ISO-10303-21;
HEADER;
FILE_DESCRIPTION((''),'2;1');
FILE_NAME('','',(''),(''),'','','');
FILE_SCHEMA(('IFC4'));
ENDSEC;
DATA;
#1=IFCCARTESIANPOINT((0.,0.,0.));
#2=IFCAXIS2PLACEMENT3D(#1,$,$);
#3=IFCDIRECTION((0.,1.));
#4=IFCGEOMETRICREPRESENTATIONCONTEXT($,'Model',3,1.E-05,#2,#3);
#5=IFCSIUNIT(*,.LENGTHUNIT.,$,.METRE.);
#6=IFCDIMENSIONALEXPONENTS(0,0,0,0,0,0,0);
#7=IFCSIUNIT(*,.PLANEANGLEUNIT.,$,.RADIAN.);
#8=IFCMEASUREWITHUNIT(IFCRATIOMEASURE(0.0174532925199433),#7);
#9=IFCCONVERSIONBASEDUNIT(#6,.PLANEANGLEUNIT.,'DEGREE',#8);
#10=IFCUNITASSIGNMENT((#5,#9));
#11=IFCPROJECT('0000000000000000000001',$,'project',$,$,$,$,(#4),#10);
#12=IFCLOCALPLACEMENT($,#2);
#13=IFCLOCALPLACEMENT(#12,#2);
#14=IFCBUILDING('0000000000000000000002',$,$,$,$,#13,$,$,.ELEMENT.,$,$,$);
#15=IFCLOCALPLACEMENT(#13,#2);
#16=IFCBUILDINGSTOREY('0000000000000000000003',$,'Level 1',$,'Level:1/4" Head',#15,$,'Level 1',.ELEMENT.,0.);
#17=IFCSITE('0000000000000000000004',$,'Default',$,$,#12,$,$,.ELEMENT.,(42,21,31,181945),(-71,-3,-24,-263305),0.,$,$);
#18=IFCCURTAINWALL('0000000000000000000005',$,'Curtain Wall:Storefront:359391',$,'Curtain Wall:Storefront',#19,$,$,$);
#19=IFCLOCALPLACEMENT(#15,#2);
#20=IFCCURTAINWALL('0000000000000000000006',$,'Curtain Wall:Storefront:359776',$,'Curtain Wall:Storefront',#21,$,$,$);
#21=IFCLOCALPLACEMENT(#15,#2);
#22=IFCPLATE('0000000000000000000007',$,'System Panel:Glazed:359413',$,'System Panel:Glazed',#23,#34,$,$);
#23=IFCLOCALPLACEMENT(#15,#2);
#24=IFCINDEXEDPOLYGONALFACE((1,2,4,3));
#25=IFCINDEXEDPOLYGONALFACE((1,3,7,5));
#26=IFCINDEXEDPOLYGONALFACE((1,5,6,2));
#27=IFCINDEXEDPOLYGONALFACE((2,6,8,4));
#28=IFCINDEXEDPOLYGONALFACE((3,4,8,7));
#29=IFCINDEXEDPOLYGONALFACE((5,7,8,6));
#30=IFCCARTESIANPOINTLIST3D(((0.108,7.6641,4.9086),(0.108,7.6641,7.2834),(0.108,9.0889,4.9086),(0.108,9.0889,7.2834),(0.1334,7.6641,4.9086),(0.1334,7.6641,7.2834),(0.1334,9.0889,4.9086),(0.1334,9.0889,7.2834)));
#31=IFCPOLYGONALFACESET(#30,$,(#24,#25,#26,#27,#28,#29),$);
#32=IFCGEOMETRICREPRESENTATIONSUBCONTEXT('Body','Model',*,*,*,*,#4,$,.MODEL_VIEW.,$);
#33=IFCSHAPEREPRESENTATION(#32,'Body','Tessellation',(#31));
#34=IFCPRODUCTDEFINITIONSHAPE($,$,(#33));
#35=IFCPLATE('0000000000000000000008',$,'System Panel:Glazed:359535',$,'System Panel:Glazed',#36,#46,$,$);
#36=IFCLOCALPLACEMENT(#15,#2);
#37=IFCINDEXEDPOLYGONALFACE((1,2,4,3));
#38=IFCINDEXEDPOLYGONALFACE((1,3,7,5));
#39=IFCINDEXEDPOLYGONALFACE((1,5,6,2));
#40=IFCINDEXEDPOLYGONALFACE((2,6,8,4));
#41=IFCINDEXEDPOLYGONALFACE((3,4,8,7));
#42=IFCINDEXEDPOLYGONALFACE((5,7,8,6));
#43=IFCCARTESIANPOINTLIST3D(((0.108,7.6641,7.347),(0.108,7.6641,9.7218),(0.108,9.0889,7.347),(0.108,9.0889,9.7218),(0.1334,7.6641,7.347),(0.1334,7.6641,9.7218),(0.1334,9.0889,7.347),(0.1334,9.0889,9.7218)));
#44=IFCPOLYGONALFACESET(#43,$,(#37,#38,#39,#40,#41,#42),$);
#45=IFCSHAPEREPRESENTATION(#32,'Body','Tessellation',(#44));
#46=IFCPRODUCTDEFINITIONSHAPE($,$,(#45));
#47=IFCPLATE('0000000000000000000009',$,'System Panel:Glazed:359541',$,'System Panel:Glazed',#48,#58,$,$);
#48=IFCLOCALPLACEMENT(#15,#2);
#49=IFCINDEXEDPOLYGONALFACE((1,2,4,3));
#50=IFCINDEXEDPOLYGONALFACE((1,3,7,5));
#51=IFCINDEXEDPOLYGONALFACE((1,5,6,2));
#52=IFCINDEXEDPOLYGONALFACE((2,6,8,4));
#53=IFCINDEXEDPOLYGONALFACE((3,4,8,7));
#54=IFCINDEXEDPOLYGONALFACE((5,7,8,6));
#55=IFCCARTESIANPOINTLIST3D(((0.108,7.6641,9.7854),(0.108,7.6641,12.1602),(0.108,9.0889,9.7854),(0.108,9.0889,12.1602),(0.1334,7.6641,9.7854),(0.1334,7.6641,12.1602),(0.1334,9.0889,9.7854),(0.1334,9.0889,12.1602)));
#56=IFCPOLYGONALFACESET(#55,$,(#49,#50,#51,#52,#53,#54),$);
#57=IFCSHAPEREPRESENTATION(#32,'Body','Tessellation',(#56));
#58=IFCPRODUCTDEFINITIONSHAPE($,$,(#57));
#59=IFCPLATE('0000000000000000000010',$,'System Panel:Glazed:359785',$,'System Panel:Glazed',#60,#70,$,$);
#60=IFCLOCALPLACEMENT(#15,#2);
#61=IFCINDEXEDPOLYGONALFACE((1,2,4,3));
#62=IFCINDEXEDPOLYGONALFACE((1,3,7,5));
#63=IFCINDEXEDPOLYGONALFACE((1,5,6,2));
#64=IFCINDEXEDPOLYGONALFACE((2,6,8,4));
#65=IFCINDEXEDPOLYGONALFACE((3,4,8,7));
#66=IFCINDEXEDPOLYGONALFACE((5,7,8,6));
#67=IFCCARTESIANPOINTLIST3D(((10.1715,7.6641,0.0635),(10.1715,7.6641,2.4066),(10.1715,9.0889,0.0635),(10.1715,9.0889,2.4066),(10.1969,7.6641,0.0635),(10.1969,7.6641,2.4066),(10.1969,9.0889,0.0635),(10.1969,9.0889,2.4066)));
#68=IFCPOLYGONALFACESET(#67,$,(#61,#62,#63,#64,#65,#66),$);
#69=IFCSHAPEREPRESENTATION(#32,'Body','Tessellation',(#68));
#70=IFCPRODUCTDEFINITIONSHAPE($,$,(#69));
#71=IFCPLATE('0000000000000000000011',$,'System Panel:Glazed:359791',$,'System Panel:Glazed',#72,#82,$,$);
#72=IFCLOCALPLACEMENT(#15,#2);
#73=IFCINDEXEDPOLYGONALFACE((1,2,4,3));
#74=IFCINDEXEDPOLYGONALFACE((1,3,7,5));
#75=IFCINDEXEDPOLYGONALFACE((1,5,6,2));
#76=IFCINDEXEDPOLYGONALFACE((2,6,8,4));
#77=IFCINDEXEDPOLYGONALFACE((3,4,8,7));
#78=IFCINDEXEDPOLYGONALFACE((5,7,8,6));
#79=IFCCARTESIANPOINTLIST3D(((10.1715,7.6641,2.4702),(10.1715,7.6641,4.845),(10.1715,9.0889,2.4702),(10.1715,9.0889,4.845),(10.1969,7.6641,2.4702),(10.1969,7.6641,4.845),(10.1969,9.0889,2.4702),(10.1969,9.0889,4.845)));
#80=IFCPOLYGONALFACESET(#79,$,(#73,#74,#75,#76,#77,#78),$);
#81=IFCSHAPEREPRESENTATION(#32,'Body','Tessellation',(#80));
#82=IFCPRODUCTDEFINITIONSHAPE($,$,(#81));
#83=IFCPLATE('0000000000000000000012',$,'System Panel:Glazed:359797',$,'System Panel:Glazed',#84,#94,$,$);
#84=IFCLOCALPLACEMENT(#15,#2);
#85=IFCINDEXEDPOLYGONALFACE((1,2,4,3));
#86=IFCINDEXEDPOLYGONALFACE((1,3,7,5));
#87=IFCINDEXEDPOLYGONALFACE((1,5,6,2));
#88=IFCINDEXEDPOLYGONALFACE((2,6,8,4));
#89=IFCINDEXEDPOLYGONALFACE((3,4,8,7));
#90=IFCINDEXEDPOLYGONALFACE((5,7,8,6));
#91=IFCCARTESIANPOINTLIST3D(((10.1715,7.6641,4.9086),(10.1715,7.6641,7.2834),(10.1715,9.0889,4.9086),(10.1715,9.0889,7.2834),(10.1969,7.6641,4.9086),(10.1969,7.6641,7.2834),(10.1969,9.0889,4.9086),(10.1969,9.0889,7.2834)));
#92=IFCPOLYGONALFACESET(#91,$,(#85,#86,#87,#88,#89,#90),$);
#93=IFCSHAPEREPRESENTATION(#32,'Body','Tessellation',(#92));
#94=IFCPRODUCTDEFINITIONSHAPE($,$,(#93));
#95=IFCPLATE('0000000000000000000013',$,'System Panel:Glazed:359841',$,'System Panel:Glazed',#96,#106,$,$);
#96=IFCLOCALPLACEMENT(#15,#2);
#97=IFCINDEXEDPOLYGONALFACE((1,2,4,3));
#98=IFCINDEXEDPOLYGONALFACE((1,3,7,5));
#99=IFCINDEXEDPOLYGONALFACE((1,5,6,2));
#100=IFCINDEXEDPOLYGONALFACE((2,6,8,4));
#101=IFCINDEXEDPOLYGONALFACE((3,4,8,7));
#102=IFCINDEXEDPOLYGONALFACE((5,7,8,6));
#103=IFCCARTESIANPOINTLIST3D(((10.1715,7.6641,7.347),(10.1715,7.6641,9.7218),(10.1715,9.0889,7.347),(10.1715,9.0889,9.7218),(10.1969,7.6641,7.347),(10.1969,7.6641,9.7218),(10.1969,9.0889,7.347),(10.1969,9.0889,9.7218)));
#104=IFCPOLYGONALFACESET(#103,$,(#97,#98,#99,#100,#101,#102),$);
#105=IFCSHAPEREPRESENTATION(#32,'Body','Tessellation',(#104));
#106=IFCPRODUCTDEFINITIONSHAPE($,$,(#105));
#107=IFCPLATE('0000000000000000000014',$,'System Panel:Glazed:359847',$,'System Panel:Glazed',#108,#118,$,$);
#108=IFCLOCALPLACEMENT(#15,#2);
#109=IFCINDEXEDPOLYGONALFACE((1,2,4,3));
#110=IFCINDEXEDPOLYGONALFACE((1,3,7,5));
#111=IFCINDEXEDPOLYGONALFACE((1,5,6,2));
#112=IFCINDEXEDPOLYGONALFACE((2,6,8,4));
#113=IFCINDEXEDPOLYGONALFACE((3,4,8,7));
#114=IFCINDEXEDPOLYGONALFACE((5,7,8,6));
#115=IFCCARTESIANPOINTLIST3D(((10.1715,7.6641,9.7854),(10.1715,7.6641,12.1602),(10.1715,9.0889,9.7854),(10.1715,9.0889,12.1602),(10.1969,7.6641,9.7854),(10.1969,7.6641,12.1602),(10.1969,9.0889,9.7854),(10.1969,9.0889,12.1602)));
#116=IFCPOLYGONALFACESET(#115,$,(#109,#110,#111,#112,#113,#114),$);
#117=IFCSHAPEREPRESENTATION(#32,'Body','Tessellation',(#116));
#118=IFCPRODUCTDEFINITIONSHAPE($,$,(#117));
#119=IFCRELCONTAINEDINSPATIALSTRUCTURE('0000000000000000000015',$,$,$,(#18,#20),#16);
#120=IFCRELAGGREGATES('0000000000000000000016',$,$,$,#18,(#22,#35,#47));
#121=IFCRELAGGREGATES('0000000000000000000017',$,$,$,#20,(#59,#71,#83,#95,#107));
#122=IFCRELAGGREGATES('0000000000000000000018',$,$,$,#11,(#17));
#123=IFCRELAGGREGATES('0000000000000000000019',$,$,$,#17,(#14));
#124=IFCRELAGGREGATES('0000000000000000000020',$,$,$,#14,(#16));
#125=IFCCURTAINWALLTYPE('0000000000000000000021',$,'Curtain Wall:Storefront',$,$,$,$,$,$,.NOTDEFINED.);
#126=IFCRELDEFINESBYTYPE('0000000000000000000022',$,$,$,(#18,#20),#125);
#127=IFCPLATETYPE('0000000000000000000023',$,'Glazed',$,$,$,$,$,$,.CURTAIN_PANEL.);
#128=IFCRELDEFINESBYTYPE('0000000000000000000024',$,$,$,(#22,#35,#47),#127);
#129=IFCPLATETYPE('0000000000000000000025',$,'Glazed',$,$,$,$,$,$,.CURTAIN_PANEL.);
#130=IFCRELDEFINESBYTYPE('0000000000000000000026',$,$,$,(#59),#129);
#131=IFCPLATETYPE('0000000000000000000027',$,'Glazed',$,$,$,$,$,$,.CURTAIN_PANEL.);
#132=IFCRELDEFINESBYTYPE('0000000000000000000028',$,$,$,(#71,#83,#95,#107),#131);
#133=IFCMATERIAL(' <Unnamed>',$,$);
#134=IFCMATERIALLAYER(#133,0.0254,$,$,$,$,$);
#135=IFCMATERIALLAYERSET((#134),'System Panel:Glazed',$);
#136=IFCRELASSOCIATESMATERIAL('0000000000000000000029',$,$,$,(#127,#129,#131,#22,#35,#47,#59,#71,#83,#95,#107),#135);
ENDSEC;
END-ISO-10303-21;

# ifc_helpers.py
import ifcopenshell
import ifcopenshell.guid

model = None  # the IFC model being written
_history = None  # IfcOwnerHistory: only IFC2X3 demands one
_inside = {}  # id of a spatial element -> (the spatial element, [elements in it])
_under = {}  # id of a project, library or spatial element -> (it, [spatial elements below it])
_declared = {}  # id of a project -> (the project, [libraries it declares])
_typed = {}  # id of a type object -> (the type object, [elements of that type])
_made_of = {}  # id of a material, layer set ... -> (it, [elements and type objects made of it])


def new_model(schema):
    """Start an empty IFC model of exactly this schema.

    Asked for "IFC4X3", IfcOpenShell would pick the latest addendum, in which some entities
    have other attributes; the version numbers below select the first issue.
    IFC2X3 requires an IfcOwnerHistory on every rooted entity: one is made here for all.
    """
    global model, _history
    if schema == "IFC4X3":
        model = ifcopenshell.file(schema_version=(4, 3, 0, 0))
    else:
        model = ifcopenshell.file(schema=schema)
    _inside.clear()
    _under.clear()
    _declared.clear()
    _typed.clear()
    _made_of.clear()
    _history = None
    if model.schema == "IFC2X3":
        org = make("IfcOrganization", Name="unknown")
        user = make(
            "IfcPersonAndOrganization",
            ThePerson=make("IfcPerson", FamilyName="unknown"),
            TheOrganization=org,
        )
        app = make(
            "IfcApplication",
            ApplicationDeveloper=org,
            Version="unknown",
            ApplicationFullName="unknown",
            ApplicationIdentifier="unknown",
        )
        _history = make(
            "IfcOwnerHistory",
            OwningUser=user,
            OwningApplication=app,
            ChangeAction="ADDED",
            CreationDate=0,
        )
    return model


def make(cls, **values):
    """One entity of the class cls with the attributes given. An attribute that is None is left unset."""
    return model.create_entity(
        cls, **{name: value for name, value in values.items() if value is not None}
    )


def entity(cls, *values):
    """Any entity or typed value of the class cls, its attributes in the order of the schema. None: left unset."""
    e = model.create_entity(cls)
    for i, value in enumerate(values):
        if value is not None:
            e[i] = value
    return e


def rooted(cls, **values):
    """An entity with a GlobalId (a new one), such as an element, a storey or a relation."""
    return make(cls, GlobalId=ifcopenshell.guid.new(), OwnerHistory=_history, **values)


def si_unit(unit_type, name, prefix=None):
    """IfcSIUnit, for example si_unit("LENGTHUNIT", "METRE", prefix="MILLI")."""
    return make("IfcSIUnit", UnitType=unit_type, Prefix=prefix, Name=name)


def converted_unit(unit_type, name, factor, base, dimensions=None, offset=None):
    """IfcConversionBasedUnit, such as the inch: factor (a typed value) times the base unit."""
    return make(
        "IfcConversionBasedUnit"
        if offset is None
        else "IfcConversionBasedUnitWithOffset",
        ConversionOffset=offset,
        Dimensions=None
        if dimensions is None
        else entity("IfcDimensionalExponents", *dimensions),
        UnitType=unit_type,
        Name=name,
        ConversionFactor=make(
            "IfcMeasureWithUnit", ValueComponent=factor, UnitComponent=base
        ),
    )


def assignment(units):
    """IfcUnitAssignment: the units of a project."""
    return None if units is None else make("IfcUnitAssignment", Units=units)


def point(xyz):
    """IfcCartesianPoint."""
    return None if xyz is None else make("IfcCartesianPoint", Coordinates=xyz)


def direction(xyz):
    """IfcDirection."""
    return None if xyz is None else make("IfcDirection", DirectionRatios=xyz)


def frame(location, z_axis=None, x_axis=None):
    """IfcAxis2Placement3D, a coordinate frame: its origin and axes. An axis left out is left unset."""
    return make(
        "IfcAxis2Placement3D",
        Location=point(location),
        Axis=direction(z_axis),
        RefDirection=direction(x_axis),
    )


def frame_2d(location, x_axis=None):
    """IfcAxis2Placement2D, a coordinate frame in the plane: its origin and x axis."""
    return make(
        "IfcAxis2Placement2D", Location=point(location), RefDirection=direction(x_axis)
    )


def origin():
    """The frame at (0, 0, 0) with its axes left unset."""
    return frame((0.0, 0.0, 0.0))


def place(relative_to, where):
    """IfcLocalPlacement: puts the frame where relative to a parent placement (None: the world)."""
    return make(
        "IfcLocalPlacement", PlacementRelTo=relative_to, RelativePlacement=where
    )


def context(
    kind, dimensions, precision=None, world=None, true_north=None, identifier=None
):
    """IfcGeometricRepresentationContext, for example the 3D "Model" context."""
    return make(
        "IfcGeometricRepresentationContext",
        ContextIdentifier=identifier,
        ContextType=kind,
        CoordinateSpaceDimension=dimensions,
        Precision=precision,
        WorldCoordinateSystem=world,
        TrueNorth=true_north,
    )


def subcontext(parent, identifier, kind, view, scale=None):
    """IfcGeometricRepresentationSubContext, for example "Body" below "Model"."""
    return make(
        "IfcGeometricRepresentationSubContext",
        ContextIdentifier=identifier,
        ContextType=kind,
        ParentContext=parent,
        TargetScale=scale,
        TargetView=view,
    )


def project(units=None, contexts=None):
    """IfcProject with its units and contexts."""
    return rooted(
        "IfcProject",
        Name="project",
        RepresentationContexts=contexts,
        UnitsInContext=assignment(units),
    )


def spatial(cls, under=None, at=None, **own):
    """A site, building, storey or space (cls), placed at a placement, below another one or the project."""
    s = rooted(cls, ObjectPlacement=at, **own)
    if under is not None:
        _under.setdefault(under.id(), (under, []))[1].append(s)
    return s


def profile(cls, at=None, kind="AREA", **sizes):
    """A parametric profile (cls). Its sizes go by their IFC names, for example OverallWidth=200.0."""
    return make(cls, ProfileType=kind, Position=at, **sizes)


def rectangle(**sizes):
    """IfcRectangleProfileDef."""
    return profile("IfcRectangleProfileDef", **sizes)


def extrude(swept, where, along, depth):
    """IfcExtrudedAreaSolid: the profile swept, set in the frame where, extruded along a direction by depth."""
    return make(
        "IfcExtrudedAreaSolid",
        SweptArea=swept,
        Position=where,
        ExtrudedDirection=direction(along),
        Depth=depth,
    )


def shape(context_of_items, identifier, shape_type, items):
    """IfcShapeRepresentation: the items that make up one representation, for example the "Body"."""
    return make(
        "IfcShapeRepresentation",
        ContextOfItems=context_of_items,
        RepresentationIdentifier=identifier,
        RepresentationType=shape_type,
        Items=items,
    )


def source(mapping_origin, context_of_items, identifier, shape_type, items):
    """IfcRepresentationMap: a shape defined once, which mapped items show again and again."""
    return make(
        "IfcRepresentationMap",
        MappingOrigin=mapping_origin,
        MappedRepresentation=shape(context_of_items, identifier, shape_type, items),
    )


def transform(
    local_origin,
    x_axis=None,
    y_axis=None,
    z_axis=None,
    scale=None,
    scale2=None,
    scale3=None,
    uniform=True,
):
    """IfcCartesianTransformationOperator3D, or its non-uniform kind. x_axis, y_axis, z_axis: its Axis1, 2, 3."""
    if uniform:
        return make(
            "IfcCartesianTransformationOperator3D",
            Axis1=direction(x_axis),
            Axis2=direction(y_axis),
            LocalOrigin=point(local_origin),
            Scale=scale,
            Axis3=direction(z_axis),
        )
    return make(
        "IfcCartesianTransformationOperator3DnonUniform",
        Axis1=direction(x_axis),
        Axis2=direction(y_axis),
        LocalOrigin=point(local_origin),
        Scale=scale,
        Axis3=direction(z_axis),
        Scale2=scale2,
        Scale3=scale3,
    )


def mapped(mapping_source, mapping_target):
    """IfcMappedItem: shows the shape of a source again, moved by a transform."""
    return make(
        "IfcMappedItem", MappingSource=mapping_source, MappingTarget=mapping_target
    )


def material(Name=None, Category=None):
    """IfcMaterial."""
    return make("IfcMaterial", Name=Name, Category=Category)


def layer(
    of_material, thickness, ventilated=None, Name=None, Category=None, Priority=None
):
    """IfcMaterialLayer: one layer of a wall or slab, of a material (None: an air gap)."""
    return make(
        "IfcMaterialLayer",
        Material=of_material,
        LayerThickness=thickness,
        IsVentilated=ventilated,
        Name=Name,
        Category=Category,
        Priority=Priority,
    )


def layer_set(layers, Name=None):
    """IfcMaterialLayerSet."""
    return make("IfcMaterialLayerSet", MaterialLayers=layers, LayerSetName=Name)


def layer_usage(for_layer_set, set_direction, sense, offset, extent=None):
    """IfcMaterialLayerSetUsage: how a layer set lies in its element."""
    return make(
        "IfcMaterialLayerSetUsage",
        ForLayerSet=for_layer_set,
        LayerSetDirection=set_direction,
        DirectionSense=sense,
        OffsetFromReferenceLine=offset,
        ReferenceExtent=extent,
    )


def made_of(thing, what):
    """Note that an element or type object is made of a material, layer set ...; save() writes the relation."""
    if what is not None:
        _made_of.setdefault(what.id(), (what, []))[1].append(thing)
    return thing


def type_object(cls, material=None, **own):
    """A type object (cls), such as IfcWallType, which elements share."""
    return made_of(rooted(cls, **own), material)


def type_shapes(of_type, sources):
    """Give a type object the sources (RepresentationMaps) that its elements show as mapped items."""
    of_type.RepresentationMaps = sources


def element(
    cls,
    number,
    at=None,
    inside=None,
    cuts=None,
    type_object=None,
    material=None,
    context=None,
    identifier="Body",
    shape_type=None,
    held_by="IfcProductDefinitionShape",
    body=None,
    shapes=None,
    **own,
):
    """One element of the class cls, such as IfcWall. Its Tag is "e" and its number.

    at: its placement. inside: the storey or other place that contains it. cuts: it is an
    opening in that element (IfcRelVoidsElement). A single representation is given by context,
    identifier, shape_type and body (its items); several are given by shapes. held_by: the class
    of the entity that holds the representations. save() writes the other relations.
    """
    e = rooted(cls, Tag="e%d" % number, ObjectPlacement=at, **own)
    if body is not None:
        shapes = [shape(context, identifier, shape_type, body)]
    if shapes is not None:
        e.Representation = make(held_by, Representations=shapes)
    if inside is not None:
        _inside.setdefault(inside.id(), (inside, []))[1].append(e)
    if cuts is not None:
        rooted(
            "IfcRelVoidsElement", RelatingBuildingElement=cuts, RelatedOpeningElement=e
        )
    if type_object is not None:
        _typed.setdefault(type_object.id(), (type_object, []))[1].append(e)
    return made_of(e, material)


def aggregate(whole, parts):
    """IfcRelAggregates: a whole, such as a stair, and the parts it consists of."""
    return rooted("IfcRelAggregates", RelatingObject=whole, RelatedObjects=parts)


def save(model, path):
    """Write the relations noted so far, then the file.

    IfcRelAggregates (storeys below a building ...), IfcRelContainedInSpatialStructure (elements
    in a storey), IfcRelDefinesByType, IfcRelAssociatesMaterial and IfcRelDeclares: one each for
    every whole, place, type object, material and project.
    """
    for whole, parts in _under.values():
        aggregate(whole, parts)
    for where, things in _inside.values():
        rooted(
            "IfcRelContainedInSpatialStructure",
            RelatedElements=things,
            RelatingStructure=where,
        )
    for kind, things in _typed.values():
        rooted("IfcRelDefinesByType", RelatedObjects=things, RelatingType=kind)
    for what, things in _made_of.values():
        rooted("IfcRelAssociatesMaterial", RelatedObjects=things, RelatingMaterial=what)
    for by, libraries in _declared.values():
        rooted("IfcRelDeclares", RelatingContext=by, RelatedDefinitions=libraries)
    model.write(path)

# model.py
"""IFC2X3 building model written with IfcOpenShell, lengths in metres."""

from ifc_helpers import new_model, entity, si_unit, converted_unit, direction, frame, frame_2d, origin, place, context, subcontext, project, spatial, rectangle, extrude, source, transform, mapped, material, layer, layer_set, layer_usage, type_object, type_shapes, element, aggregate, save


model = new_model("IFC2X3")

# Units and contexts
model_context = context("Model", 3, precision=1e-05, world=origin(), true_north=direction((0.0, 1.0)))
body_context = subcontext(model_context, "Body", "Model", "MODEL_VIEW")
ifc_project = project(units=[si_unit("LENGTHUNIT", "METRE"), converted_unit("PLANEANGLEUNIT", "DEGREE", entity("IfcRatioMeasure", 0.0174532925199433), si_unit("PLANEANGLEUNIT", "RADIAN"), dimensions=[0, 0, 0, 0, 0, 0, 0])], contexts=[model_context])

# Site, building, storey
site_placement = place(None, origin())
site = spatial("IfcSite", under=ifc_project, at=site_placement, Name="Default", CompositionType="ELEMENT", RefLatitude=(42, 21, 31, 181945), RefLongitude=(-71, -3, -24, -263305), RefElevation=0.0)
building_placement = place(site_placement, origin())
building = spatial("IfcBuilding", under=site, at=building_placement, CompositionType="ELEMENT")
storey_placement = place(building_placement, origin())
storey = spatial("IfcBuildingStorey", under=building, at=storey_placement, Name="Level 1", ObjectType="Level:1/4\" Head", LongName="Level 1", CompositionType="ELEMENT", Elevation=0.0)

# Curtain walls
curtain_wall_type = type_object("IfcCurtainWallType", Name="Curtain Wall:Storefront", PredefinedType="NOTDEFINED")
curtain_wall_1_placement = place(storey_placement, origin())
curtain_wall_1 = element("IfcCurtainWall", 1, at=curtain_wall_1_placement, inside=storey, type_object=curtain_wall_type, Name="Curtain Wall:Storefront:359391", ObjectType="Curtain Wall:Storefront")
curtain_wall_2_placement = place(storey_placement, origin())
curtain_wall_2 = element("IfcCurtainWall", 2, at=curtain_wall_2_placement, inside=storey, type_object=curtain_wall_type, Name="Curtain Wall:Storefront:359776", ObjectType="Curtain Wall:Storefront")

# Plates
ifc_material_1 = material(Name=" <Unnamed>")
ifc_layer = layer(ifc_material_1, 0.0254)
ifc_layer_set = layer_set([ifc_layer], Name="System Panel:Glazed")
plate_type_1 = type_object("IfcPlateType", Name="Glazed", PredefinedType="CURTAIN_PANEL", material=ifc_layer_set)
shared_shape_1 = source(origin(), body_context, "Body", "SweptSolid", [
    extrude(rectangle(XDim=0.0254, YDim=1.4248, at=frame_2d((0.0, 0.0), x_axis=(1.0, 0.0))), frame((0.7124, 0.0127, 0.0), z_axis=(0.0, 0.0, 1.0), x_axis=(0.0, 1.0, 0.0)), (0.0, 0.0, 1.0), 2.3749),
])
type_shapes(plate_type_1, [shared_shape_1])
ifc_layer_usage_1 = layer_usage(ifc_layer_set, "AXIS3", "POSITIVE", 0.1042)
plate_1_placement = place(curtain_wall_1_placement, frame((0.1334, 7.6641, 4.9085), z_axis=(0.0, 0.0, 1.0), x_axis=(0.0, 1.0, 0.0)))
plate_1 = element("IfcPlate", 3, at=plate_1_placement, type_object=plate_type_1, material=ifc_layer_usage_1, Name="System Panel:Glazed:359413", ObjectType="System Panel:Glazed", context=body_context, shape_type="MappedRepresentation", body=[
    mapped(shared_shape_1, transform((0.0, 0.0, 0.0), scale=1.0)),
])
ifc_layer_usage_2 = layer_usage(ifc_layer_set, "AXIS3", "POSITIVE", 0.1042)
plate_2_placement = place(curtain_wall_1_placement, frame((0.1334, 7.6641, 7.3469), z_axis=(0.0, 0.0, 1.0), x_axis=(0.0, 1.0, 0.0)))
plate_2 = element("IfcPlate", 4, at=plate_2_placement, type_object=plate_type_1, material=ifc_layer_usage_2, Name="System Panel:Glazed:359535", ObjectType="System Panel:Glazed", context=body_context, shape_type="MappedRepresentation", body=[
    mapped(shared_shape_1, transform((0.0, 0.0, 0.0), scale=1.0)),
])
ifc_layer_usage_3 = layer_usage(ifc_layer_set, "AXIS3", "POSITIVE", 0.1042)
plate_3_placement = place(curtain_wall_1_placement, frame((0.1334, 7.6641, 9.7853), z_axis=(0.0, 0.0, 1.0), x_axis=(0.0, 1.0, 0.0)))
plate_3 = element("IfcPlate", 5, at=plate_3_placement, type_object=plate_type_1, material=ifc_layer_usage_3, Name="System Panel:Glazed:359541", ObjectType="System Panel:Glazed", context=body_context, shape_type="MappedRepresentation", body=[
    mapped(shared_shape_1, transform((0.0, 0.0, 0.0), scale=1.0)),
])
aggregate(curtain_wall_1, [plate_1, plate_2, plate_3])
ifc_layer_usage_4 = layer_usage(ifc_layer_set, "AXIS3", "POSITIVE", 0.1042)
plate_type_2 = type_object("IfcPlateType", Name="Glazed", PredefinedType="CURTAIN_PANEL", material=ifc_layer_set)
shared_shape_2 = source(origin(), body_context, "Body", "SweptSolid", [
    extrude(rectangle(XDim=0.0254, YDim=1.4248, at=frame_2d((0.0, 0.0), x_axis=(1.0, 0.0))), frame((0.7124, 0.0127, 0.0), z_axis=(0.0, 0.0, 1.0), x_axis=(0.0, 1.0, 0.0)), (0.0, 0.0, 1.0), 2.3432),
])
type_shapes(plate_type_2, [shared_shape_2])
plate_4_placement = place(curtain_wall_2_placement, frame((10.1969, 7.6641, 0.0635), z_axis=(0.0, 0.0, 1.0), x_axis=(0.0, 1.0, 0.0)))
plate_4 = element("IfcPlate", 6, at=plate_4_placement, type_object=plate_type_2, material=ifc_layer_usage_4, Name="System Panel:Glazed:359785", ObjectType="System Panel:Glazed", context=body_context, shape_type="MappedRepresentation", body=[
    mapped(shared_shape_2, transform((0.0, 0.0, 0.0), scale=1.0)),
])
ifc_layer_usage_5 = layer_usage(ifc_layer_set, "AXIS3", "POSITIVE", 0.1042)
plate_type_3 = type_object("IfcPlateType", Name="Glazed", PredefinedType="CURTAIN_PANEL", material=ifc_layer_set)
shared_shape_3 = source(origin(), body_context, "Body", "SweptSolid", [
    extrude(rectangle(XDim=0.0254, YDim=1.4248, at=frame_2d((0.0, 0.0), x_axis=(1.0, 0.0))), frame((0.7124, 0.0127, 0.0), z_axis=(0.0, 0.0, 1.0), x_axis=(0.0, 1.0, 0.0)), (0.0, 0.0, 1.0), 2.3749),
])
type_shapes(plate_type_3, [shared_shape_3])
plate_5_placement = place(curtain_wall_2_placement, frame((10.1969, 7.6641, 2.4701), z_axis=(0.0, 0.0, 1.0), x_axis=(0.0, 1.0, 0.0)))
plate_5 = element("IfcPlate", 7, at=plate_5_placement, type_object=plate_type_3, material=ifc_layer_usage_5, Name="System Panel:Glazed:359791", ObjectType="System Panel:Glazed", context=body_context, shape_type="MappedRepresentation", body=[
    mapped(shared_shape_3, transform((0.0, 0.0, 0.0), scale=1.0)),
])
ifc_layer_usage_6 = layer_usage(ifc_layer_set, "AXIS3", "POSITIVE", 0.1042)
plate_6_placement = place(curtain_wall_2_placement, frame((10.1969, 7.6641, 4.9085), z_axis=(0.0, 0.0, 1.0), x_axis=(0.0, 1.0, 0.0)))
plate_6 = element("IfcPlate", 8, at=plate_6_placement, type_object=plate_type_3, material=ifc_layer_usage_6, Name="System Panel:Glazed:359797", ObjectType="System Panel:Glazed", context=body_context, shape_type="MappedRepresentation", body=[
    mapped(shared_shape_3, transform((0.0, 0.0, 0.0), scale=1.0)),
])
ifc_layer_usage_7 = layer_usage(ifc_layer_set, "AXIS3", "POSITIVE", 0.1042)
plate_7_placement = place(curtain_wall_2_placement, frame((10.1969, 7.6641, 7.3469), z_axis=(0.0, 0.0, 1.0), x_axis=(0.0, 1.0, 0.0)))
plate_7 = element("IfcPlate", 9, at=plate_7_placement, type_object=plate_type_3, material=ifc_layer_usage_7, Name="System Panel:Glazed:359841", ObjectType="System Panel:Glazed", context=body_context, shape_type="MappedRepresentation", body=[
    mapped(shared_shape_3, transform((0.0, 0.0, 0.0), scale=1.0)),
])
ifc_layer_usage_8 = layer_usage(ifc_layer_set, "AXIS3", "POSITIVE", 0.1042)
plate_8_placement = place(curtain_wall_2_placement, frame((10.1969, 7.6641, 9.7853), z_axis=(0.0, 0.0, 1.0), x_axis=(0.0, 1.0, 0.0)))
plate_8 = element("IfcPlate", 10, at=plate_8_placement, type_object=plate_type_3, material=ifc_layer_usage_8, Name="System Panel:Glazed:359847", ObjectType="System Panel:Glazed", context=body_context, shape_type="MappedRepresentation", body=[
    mapped(shared_shape_3, transform((0.0, 0.0, 0.0), scale=1.0)),
])
aggregate(curtain_wall_2, [plate_4, plate_5, plate_6, plate_7, plate_8])

save(model, "model.ifc")
